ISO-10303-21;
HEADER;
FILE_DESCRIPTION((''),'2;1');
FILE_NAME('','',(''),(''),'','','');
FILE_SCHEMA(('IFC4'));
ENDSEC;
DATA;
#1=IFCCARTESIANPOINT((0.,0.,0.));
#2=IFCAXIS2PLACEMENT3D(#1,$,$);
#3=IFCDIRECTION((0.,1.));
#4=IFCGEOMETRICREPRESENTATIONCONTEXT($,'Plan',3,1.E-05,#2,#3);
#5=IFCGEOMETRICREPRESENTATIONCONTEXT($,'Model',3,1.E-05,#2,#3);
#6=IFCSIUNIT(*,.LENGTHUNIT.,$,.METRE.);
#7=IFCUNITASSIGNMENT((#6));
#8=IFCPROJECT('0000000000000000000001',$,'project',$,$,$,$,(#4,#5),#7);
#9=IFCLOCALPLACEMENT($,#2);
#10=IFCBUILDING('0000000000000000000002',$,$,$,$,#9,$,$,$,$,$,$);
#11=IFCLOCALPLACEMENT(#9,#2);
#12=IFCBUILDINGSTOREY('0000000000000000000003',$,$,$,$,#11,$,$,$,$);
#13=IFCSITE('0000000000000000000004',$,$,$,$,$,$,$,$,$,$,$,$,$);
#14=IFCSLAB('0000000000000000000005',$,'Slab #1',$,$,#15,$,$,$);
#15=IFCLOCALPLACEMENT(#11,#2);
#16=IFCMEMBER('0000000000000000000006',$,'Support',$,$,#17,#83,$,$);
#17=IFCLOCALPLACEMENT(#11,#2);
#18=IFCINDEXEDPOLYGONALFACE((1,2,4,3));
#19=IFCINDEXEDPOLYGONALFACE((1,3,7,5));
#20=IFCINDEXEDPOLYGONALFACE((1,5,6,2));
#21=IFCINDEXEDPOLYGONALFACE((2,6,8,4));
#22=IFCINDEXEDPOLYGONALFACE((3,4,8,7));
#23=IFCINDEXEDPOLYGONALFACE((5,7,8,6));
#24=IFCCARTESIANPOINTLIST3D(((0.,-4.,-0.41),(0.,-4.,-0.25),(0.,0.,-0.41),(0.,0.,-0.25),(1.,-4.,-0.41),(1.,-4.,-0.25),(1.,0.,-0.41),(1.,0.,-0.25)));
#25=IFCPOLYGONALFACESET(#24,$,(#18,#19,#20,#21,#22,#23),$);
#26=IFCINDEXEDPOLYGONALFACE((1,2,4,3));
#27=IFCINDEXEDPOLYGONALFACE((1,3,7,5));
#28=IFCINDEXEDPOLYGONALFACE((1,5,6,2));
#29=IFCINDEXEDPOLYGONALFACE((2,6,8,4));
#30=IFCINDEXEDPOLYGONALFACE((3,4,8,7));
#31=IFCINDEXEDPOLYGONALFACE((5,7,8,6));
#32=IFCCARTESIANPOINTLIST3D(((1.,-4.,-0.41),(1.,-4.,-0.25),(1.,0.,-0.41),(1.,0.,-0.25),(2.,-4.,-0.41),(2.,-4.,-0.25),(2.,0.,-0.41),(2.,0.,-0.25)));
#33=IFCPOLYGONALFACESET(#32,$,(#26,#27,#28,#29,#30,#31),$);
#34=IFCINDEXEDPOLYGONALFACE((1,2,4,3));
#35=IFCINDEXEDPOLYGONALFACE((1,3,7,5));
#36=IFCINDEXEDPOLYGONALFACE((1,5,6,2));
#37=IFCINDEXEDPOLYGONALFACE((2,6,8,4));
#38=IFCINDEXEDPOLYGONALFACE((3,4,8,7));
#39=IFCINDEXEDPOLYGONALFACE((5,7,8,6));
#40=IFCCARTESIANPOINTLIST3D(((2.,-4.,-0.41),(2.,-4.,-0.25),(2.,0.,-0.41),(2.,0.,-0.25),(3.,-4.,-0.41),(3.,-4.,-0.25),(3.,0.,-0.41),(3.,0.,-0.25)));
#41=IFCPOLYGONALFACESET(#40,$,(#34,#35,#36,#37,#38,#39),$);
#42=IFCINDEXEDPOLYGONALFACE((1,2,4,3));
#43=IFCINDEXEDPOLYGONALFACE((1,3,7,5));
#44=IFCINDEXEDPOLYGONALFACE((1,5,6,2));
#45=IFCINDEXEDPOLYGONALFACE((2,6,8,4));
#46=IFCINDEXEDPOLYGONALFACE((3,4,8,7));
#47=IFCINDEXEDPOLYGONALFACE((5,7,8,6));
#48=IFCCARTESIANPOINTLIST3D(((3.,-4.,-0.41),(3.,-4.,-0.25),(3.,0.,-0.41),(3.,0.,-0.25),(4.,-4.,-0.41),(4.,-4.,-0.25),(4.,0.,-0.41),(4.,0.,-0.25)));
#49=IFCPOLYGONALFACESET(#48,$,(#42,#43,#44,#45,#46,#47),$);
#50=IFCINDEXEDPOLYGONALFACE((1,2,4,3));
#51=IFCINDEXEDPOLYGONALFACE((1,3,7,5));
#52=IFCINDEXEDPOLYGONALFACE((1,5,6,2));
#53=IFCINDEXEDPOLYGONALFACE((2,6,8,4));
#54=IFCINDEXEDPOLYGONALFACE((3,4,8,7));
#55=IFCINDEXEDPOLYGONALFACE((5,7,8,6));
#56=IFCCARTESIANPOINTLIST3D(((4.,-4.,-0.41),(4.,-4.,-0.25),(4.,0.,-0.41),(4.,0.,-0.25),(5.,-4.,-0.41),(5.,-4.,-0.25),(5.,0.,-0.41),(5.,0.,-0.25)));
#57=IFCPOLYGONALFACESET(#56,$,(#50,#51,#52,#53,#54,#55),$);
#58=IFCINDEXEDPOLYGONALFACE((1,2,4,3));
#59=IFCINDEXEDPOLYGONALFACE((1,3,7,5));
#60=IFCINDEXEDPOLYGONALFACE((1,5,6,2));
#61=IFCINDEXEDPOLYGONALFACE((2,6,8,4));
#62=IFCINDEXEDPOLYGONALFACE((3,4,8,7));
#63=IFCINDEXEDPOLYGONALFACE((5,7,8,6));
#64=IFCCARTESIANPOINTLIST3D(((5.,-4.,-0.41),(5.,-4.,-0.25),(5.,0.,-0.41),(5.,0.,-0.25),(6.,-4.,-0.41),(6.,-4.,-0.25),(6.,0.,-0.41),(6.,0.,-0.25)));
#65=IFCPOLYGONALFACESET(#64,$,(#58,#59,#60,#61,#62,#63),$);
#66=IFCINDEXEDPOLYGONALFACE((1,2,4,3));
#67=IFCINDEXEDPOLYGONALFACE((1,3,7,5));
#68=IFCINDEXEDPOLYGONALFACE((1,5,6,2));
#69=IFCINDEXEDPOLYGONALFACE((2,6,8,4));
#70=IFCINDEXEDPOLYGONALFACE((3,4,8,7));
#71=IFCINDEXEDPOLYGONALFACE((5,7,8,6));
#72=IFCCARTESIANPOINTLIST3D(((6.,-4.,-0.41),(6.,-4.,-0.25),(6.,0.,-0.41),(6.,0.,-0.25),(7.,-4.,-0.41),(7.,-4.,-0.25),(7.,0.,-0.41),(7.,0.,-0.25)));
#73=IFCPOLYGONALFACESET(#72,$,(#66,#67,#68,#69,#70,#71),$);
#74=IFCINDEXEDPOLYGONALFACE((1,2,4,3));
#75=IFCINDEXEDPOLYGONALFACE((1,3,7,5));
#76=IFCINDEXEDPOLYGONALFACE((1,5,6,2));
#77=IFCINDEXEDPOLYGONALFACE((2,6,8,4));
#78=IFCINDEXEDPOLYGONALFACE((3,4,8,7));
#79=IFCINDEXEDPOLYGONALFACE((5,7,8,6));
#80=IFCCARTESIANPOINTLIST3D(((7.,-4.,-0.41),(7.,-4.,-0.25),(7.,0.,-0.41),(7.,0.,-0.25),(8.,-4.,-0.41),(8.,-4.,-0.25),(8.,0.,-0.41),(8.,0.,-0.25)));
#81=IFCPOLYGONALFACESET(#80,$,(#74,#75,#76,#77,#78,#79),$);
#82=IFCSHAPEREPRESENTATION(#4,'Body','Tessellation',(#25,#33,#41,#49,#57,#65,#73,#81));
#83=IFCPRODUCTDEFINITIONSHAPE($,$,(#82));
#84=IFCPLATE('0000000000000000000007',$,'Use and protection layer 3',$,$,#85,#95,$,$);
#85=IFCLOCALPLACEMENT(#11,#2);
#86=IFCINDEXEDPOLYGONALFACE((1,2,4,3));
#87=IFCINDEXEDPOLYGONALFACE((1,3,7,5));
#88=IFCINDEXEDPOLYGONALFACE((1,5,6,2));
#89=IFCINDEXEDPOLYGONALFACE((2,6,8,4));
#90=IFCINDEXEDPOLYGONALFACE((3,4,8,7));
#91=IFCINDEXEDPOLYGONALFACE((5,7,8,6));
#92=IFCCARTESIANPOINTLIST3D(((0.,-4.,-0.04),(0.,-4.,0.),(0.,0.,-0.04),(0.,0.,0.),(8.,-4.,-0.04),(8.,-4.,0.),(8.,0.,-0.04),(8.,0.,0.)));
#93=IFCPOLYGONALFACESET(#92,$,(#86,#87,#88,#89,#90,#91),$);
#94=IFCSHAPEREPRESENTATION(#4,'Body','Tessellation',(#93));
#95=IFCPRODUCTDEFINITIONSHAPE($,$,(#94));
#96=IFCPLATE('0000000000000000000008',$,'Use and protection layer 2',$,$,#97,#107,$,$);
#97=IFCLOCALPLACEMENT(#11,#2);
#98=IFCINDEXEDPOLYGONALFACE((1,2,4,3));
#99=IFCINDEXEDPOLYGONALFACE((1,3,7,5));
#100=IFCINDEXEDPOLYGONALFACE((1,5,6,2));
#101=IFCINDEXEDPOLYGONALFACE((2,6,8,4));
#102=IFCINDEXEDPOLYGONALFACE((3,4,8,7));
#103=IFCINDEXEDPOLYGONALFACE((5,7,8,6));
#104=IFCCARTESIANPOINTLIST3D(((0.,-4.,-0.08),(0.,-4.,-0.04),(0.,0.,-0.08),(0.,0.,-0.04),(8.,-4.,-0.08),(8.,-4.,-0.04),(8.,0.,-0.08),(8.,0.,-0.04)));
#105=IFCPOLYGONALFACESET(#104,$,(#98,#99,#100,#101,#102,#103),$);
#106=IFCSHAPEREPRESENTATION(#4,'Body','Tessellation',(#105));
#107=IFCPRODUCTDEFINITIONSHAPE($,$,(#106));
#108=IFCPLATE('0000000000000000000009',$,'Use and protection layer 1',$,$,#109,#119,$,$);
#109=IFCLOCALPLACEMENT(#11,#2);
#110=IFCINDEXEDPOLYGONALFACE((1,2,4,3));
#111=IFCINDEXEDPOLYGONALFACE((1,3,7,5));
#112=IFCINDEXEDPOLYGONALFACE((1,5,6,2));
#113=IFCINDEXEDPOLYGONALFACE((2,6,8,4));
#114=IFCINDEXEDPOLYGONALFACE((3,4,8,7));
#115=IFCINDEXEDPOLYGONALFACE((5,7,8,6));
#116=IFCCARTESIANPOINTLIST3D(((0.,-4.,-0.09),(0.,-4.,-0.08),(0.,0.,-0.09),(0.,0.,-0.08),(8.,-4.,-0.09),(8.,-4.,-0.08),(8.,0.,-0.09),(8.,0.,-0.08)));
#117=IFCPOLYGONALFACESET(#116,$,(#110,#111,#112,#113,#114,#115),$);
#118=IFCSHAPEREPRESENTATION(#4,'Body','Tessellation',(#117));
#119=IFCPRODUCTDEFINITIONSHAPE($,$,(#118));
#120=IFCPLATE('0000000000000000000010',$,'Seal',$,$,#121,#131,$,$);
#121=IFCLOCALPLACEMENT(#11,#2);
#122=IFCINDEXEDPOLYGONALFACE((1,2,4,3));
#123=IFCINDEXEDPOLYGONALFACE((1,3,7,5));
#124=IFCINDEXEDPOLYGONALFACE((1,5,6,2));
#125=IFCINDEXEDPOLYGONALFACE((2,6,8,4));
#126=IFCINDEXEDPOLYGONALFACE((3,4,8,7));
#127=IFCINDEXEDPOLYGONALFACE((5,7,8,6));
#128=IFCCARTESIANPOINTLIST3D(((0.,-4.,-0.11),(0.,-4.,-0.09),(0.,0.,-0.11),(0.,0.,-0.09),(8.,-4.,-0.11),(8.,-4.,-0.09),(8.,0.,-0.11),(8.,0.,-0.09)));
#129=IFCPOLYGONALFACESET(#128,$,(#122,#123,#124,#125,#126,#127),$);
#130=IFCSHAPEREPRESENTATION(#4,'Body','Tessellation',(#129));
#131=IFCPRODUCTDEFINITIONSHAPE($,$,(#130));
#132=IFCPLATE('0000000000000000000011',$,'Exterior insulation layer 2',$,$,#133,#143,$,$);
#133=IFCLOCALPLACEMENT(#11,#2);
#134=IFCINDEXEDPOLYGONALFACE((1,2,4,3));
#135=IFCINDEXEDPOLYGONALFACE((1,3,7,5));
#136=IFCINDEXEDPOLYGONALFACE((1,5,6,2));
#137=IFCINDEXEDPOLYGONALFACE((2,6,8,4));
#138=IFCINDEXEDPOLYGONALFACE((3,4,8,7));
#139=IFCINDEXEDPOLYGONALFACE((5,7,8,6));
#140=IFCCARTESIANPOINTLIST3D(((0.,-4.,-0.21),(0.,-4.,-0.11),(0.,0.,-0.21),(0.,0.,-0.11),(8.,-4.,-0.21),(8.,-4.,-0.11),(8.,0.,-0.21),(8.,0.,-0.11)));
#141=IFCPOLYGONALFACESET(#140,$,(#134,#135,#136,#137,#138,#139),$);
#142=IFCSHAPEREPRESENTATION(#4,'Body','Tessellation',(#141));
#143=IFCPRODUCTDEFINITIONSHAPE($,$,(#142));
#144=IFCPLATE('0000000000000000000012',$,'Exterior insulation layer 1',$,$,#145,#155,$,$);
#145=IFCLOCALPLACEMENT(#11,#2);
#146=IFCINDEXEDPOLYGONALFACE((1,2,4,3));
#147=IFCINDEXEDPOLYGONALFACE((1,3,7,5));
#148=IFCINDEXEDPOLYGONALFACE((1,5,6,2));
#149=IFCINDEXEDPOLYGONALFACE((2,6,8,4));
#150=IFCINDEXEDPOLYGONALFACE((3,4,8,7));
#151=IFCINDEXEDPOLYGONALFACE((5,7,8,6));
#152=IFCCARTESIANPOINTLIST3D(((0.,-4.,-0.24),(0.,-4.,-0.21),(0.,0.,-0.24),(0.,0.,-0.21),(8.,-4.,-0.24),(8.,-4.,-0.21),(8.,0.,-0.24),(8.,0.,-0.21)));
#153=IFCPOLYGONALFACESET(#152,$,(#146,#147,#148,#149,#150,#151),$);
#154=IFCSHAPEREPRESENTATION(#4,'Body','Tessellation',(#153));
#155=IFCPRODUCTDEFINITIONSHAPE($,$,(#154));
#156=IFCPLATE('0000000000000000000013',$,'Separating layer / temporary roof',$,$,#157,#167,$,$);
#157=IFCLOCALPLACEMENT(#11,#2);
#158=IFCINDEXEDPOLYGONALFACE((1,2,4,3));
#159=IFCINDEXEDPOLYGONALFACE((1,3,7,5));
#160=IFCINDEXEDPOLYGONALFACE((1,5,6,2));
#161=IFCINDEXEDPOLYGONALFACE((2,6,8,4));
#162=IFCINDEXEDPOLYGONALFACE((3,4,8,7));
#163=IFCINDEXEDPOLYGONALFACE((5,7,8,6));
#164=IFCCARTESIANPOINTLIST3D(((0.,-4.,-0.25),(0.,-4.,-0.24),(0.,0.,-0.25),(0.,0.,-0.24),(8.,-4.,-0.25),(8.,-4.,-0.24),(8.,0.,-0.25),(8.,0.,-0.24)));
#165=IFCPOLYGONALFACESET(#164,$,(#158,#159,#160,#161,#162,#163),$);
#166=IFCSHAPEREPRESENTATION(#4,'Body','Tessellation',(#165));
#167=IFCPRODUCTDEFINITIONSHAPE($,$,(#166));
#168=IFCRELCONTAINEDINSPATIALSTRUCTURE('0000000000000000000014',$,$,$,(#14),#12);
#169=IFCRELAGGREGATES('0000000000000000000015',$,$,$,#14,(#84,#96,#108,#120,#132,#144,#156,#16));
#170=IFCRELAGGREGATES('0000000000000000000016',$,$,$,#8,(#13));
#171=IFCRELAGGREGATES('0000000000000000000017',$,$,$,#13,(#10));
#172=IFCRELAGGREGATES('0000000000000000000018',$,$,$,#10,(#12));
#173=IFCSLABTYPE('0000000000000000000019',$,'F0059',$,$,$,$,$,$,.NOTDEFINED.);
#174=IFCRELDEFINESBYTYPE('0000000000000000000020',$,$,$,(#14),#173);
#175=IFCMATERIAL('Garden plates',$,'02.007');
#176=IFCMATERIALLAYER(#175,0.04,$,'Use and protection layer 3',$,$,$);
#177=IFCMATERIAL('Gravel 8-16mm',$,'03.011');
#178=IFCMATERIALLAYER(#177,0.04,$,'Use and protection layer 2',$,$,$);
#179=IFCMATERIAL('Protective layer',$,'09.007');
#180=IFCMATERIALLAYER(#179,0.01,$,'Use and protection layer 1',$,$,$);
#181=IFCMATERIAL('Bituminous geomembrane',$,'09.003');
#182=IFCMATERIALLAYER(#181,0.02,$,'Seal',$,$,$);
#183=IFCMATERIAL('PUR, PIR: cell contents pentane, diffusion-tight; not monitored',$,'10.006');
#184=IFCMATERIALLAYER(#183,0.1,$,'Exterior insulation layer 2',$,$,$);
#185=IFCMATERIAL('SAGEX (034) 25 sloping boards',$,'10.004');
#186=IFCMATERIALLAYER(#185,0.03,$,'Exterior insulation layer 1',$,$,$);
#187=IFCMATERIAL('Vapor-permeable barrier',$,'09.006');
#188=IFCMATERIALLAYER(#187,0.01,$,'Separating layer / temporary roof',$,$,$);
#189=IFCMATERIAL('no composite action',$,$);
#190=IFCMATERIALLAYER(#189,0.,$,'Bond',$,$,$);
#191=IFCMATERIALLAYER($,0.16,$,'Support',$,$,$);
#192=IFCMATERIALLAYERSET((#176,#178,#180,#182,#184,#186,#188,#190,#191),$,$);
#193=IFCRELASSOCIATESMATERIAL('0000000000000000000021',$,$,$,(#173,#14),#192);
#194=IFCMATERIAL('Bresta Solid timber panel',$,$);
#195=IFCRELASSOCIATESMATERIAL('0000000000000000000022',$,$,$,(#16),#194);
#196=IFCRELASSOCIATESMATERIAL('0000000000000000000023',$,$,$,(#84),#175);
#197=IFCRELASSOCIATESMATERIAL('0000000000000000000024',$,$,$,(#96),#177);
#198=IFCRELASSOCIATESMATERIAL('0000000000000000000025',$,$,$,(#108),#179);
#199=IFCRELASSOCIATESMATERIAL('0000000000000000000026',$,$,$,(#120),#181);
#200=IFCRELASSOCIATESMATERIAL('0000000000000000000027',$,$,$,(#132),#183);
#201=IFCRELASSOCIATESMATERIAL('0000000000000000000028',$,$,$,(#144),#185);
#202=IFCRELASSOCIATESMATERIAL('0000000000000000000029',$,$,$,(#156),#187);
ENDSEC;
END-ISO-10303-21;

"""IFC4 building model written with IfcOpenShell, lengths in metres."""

from ifc_helpers import new_model, si_unit, direction, frame, frame_2d, origin, origin_with_axes, place, context, project, spatial, rectangle, extrude, material, layer, layer_set, type_object, element, aggregate, save


model = new_model("IFC4")

# Units and contexts
plan_context = context("Plan", 3, precision=1e-05, world=origin(), true_north=direction((0.0, 1.0)))
model_context = context("Model", 3, precision=1e-05, world=origin(), true_north=direction((0.0, 1.0)))
ifc_project = project(units=[si_unit("LENGTHUNIT", "METRE")], contexts=[plan_context, model_context])

# Site, building, storey
site = spatial("IfcSite", under=ifc_project)
building_placement = place(None, origin())
building = spatial("IfcBuilding", under=site, at=building_placement)
storey_placement = place(building_placement, origin())
storey = spatial("IfcBuildingStorey", under=building, at=storey_placement)

# Slab, member, plates
ifc_material_1 = material(Name="Garden plates", Category="02.007")
ifc_layer_1 = layer(ifc_material_1, 0.04, Name="Use and protection layer 3")
ifc_material_2 = material(Name="Gravel 8-16mm", Category="03.011")
ifc_layer_2 = layer(ifc_material_2, 0.04, Name="Use and protection layer 2")
ifc_material_3 = material(Name="Protective layer", Category="09.007")
ifc_layer_3 = layer(ifc_material_3, 0.01, Name="Use and protection layer 1")
ifc_material_4 = material(Name="Bituminous geomembrane", Category="09.003")
ifc_layer_4 = layer(ifc_material_4, 0.02, Name="Seal")
ifc_material_5 = material(Name="PUR, PIR: cell contents pentane, diffusion-tight; not monitored", Category="10.006")
ifc_layer_5 = layer(ifc_material_5, 0.1, Name="Exterior insulation layer 2")
ifc_material_6 = material(Name="SAGEX (034) 25 sloping boards", Category="10.004")
ifc_layer_6 = layer(ifc_material_6, 0.03, Name="Exterior insulation layer 1")
ifc_material_7 = material(Name="Vapor-permeable barrier", Category="09.006")
ifc_layer_7 = layer(ifc_material_7, 0.01, Name="Separating layer / temporary roof")
ifc_material_8 = material(Name="no composite action")
ifc_layer_8 = layer(ifc_material_8, 0.0, Name="Bond")
ifc_layer_9 = layer(None, 0.16, Name="Support")
ifc_layer_set = layer_set([ifc_layer_1, ifc_layer_2, ifc_layer_3, ifc_layer_4, ifc_layer_5, ifc_layer_6, ifc_layer_7, ifc_layer_8, ifc_layer_9])
slab_type = type_object("IfcSlabType", Name="F0059", PredefinedType="NOTDEFINED", material=ifc_layer_set)
slab_placement = place(None, frame((0.0, 0.0, 0.0), z_axis=(0.0, 0.0, -1.0), x_axis=(1.0, 0.0, 0.0)))
slab = element("IfcSlab", 1, at=slab_placement, inside=storey, type_object=slab_type, material=ifc_layer_set, Name="Slab #1")
ifc_material_9 = material(Name="Bresta Solid timber panel")
member_placement = place(slab_placement, origin())
member = element("IfcMember", 2, at=member_placement, material=ifc_material_9, Name="Support", context=plan_context, shape_type="SweptSolid", body=[
    extrude(rectangle(XDim=1.0, YDim=0.16, at=frame_2d((0.5, 0.08), x_axis=(1.0, 0.0))), frame((0.0, 4.0, 0.25), z_axis=(0.0, -1.0, 0.0), x_axis=(1.0, 0.0, 0.0)), (0.0, 0.0, 1.0), 4.0),
    extrude(rectangle(XDim=1.0, YDim=0.16, at=frame_2d((0.5, 0.08), x_axis=(1.0, 0.0))), frame((1.0, 4.0, 0.25), z_axis=(0.0, -1.0, 0.0), x_axis=(1.0, 0.0, 0.0)), (0.0, 0.0, 1.0), 4.0),
    extrude(rectangle(XDim=1.0, YDim=0.16, at=frame_2d((0.5, 0.08), x_axis=(1.0, 0.0))), frame((2.0, 4.0, 0.25), z_axis=(0.0, -1.0, 0.0), x_axis=(1.0, 0.0, 0.0)), (0.0, 0.0, 1.0), 4.0),
    extrude(rectangle(XDim=1.0, YDim=0.16, at=frame_2d((0.5, 0.08), x_axis=(1.0, 0.0))), frame((3.0, 4.0, 0.25), z_axis=(0.0, -1.0, 0.0), x_axis=(1.0, 0.0, 0.0)), (0.0, 0.0, 1.0), 4.0),
    extrude(rectangle(XDim=1.0, YDim=0.16, at=frame_2d((0.5, 0.08), x_axis=(1.0, 0.0))), frame((4.0, 4.0, 0.25), z_axis=(0.0, -1.0, 0.0), x_axis=(1.0, 0.0, 0.0)), (0.0, 0.0, 1.0), 4.0),
    extrude(rectangle(XDim=1.0, YDim=0.16, at=frame_2d((0.5, 0.08), x_axis=(1.0, 0.0))), frame((5.0, 4.0, 0.25), z_axis=(0.0, -1.0, 0.0), x_axis=(1.0, 0.0, 0.0)), (0.0, 0.0, 1.0), 4.0),
    extrude(rectangle(XDim=1.0, YDim=0.16, at=frame_2d((0.5, 0.08), x_axis=(1.0, 0.0))), frame((6.0, 4.0, 0.25), z_axis=(0.0, -1.0, 0.0), x_axis=(1.0, 0.0, 0.0)), (0.0, 0.0, 1.0), 4.0),
    extrude(rectangle(XDim=1.0, YDim=0.16, at=frame_2d((0.5, 0.08), x_axis=(1.0, 0.0))), frame((7.0, 4.0, 0.25), z_axis=(0.0, -1.0, 0.0), x_axis=(1.0, 0.0, 0.0)), (0.0, 0.0, 1.0), 4.0),
])
plate_1_placement = place(slab_placement, origin())
plate_1 = element("IfcPlate", 3, at=plate_1_placement, material=ifc_material_1, Name="Use and protection layer 3", context=plan_context, shape_type="SweptSolid", body=[
    extrude(rectangle(XDim=8.0, YDim=4.0, at=frame_2d((4.0, 2.0), x_axis=(1.0, 0.0))), origin_with_axes(), (0.0, 0.0, 1.0), 0.04),
])
plate_2_placement = place(slab_placement, origin())
plate_2 = element("IfcPlate", 4, at=plate_2_placement, material=ifc_material_2, Name="Use and protection layer 2", context=plan_context, shape_type="SweptSolid", body=[
    extrude(rectangle(XDim=8.0, YDim=4.0, at=frame_2d((4.0, 2.0), x_axis=(1.0, 0.0))), frame((0.0, 0.0, 0.04), z_axis=(0.0, 0.0, 1.0), x_axis=(1.0, 0.0, 0.0)), (0.0, 0.0, 1.0), 0.04),
])
plate_3_placement = place(slab_placement, origin())
plate_3 = element("IfcPlate", 5, at=plate_3_placement, material=ifc_material_3, Name="Use and protection layer 1", context=plan_context, shape_type="SweptSolid", body=[
    extrude(rectangle(XDim=8.0, YDim=4.0, at=frame_2d((4.0, 2.0), x_axis=(1.0, 0.0))), frame((0.0, 0.0, 0.08), z_axis=(0.0, 0.0, 1.0), x_axis=(1.0, 0.0, 0.0)), (0.0, 0.0, 1.0), 0.01),
])
plate_4_placement = place(slab_placement, origin())
plate_4 = element("IfcPlate", 6, at=plate_4_placement, material=ifc_material_4, Name="Seal", context=plan_context, shape_type="SweptSolid", body=[
    extrude(rectangle(XDim=8.0, YDim=4.0, at=frame_2d((4.0, 2.0), x_axis=(1.0, 0.0))), frame((0.0, 0.0, 0.09), z_axis=(0.0, 0.0, 1.0), x_axis=(1.0, 0.0, 0.0)), (0.0, 0.0, 1.0), 0.02),
])
plate_5_placement = place(slab_placement, origin())
plate_5 = element("IfcPlate", 7, at=plate_5_placement, material=ifc_material_5, Name="Exterior insulation layer 2", context=plan_context, shape_type="SweptSolid", body=[
    extrude(rectangle(XDim=8.0, YDim=4.0, at=frame_2d((4.0, 2.0), x_axis=(1.0, 0.0))), frame((0.0, 0.0, 0.11), z_axis=(0.0, 0.0, 1.0), x_axis=(1.0, 0.0, 0.0)), (0.0, 0.0, 1.0), 0.1),
])
plate_6_placement = place(slab_placement, origin())
plate_6 = element("IfcPlate", 8, at=plate_6_placement, material=ifc_material_6, Name="Exterior insulation layer 1", context=plan_context, shape_type="SweptSolid", body=[
    extrude(rectangle(XDim=8.0, YDim=4.0, at=frame_2d((4.0, 2.0), x_axis=(1.0, 0.0))), frame((0.0, 0.0, 0.21), z_axis=(0.0, 0.0, 1.0), x_axis=(1.0, 0.0, 0.0)), (0.0, 0.0, 1.0), 0.03),
])
plate_7_placement = place(slab_placement, origin())
plate_7 = element("IfcPlate", 9, at=plate_7_placement, material=ifc_material_7, Name="Separating layer / temporary roof", context=plan_context, shape_type="SweptSolid", body=[
    extrude(rectangle(XDim=8.0, YDim=4.0, at=frame_2d((4.0, 2.0), x_axis=(1.0, 0.0))), frame((0.0, 0.0, 0.24), z_axis=(0.0, 0.0, 1.0), x_axis=(1.0, 0.0, 0.0)), (0.0, 0.0, 1.0), 0.01),
])
aggregate(slab, [plate_1, plate_2, plate_3, plate_4, plate_5, plate_6, plate_7, member])

save(model, "model.ifc")
